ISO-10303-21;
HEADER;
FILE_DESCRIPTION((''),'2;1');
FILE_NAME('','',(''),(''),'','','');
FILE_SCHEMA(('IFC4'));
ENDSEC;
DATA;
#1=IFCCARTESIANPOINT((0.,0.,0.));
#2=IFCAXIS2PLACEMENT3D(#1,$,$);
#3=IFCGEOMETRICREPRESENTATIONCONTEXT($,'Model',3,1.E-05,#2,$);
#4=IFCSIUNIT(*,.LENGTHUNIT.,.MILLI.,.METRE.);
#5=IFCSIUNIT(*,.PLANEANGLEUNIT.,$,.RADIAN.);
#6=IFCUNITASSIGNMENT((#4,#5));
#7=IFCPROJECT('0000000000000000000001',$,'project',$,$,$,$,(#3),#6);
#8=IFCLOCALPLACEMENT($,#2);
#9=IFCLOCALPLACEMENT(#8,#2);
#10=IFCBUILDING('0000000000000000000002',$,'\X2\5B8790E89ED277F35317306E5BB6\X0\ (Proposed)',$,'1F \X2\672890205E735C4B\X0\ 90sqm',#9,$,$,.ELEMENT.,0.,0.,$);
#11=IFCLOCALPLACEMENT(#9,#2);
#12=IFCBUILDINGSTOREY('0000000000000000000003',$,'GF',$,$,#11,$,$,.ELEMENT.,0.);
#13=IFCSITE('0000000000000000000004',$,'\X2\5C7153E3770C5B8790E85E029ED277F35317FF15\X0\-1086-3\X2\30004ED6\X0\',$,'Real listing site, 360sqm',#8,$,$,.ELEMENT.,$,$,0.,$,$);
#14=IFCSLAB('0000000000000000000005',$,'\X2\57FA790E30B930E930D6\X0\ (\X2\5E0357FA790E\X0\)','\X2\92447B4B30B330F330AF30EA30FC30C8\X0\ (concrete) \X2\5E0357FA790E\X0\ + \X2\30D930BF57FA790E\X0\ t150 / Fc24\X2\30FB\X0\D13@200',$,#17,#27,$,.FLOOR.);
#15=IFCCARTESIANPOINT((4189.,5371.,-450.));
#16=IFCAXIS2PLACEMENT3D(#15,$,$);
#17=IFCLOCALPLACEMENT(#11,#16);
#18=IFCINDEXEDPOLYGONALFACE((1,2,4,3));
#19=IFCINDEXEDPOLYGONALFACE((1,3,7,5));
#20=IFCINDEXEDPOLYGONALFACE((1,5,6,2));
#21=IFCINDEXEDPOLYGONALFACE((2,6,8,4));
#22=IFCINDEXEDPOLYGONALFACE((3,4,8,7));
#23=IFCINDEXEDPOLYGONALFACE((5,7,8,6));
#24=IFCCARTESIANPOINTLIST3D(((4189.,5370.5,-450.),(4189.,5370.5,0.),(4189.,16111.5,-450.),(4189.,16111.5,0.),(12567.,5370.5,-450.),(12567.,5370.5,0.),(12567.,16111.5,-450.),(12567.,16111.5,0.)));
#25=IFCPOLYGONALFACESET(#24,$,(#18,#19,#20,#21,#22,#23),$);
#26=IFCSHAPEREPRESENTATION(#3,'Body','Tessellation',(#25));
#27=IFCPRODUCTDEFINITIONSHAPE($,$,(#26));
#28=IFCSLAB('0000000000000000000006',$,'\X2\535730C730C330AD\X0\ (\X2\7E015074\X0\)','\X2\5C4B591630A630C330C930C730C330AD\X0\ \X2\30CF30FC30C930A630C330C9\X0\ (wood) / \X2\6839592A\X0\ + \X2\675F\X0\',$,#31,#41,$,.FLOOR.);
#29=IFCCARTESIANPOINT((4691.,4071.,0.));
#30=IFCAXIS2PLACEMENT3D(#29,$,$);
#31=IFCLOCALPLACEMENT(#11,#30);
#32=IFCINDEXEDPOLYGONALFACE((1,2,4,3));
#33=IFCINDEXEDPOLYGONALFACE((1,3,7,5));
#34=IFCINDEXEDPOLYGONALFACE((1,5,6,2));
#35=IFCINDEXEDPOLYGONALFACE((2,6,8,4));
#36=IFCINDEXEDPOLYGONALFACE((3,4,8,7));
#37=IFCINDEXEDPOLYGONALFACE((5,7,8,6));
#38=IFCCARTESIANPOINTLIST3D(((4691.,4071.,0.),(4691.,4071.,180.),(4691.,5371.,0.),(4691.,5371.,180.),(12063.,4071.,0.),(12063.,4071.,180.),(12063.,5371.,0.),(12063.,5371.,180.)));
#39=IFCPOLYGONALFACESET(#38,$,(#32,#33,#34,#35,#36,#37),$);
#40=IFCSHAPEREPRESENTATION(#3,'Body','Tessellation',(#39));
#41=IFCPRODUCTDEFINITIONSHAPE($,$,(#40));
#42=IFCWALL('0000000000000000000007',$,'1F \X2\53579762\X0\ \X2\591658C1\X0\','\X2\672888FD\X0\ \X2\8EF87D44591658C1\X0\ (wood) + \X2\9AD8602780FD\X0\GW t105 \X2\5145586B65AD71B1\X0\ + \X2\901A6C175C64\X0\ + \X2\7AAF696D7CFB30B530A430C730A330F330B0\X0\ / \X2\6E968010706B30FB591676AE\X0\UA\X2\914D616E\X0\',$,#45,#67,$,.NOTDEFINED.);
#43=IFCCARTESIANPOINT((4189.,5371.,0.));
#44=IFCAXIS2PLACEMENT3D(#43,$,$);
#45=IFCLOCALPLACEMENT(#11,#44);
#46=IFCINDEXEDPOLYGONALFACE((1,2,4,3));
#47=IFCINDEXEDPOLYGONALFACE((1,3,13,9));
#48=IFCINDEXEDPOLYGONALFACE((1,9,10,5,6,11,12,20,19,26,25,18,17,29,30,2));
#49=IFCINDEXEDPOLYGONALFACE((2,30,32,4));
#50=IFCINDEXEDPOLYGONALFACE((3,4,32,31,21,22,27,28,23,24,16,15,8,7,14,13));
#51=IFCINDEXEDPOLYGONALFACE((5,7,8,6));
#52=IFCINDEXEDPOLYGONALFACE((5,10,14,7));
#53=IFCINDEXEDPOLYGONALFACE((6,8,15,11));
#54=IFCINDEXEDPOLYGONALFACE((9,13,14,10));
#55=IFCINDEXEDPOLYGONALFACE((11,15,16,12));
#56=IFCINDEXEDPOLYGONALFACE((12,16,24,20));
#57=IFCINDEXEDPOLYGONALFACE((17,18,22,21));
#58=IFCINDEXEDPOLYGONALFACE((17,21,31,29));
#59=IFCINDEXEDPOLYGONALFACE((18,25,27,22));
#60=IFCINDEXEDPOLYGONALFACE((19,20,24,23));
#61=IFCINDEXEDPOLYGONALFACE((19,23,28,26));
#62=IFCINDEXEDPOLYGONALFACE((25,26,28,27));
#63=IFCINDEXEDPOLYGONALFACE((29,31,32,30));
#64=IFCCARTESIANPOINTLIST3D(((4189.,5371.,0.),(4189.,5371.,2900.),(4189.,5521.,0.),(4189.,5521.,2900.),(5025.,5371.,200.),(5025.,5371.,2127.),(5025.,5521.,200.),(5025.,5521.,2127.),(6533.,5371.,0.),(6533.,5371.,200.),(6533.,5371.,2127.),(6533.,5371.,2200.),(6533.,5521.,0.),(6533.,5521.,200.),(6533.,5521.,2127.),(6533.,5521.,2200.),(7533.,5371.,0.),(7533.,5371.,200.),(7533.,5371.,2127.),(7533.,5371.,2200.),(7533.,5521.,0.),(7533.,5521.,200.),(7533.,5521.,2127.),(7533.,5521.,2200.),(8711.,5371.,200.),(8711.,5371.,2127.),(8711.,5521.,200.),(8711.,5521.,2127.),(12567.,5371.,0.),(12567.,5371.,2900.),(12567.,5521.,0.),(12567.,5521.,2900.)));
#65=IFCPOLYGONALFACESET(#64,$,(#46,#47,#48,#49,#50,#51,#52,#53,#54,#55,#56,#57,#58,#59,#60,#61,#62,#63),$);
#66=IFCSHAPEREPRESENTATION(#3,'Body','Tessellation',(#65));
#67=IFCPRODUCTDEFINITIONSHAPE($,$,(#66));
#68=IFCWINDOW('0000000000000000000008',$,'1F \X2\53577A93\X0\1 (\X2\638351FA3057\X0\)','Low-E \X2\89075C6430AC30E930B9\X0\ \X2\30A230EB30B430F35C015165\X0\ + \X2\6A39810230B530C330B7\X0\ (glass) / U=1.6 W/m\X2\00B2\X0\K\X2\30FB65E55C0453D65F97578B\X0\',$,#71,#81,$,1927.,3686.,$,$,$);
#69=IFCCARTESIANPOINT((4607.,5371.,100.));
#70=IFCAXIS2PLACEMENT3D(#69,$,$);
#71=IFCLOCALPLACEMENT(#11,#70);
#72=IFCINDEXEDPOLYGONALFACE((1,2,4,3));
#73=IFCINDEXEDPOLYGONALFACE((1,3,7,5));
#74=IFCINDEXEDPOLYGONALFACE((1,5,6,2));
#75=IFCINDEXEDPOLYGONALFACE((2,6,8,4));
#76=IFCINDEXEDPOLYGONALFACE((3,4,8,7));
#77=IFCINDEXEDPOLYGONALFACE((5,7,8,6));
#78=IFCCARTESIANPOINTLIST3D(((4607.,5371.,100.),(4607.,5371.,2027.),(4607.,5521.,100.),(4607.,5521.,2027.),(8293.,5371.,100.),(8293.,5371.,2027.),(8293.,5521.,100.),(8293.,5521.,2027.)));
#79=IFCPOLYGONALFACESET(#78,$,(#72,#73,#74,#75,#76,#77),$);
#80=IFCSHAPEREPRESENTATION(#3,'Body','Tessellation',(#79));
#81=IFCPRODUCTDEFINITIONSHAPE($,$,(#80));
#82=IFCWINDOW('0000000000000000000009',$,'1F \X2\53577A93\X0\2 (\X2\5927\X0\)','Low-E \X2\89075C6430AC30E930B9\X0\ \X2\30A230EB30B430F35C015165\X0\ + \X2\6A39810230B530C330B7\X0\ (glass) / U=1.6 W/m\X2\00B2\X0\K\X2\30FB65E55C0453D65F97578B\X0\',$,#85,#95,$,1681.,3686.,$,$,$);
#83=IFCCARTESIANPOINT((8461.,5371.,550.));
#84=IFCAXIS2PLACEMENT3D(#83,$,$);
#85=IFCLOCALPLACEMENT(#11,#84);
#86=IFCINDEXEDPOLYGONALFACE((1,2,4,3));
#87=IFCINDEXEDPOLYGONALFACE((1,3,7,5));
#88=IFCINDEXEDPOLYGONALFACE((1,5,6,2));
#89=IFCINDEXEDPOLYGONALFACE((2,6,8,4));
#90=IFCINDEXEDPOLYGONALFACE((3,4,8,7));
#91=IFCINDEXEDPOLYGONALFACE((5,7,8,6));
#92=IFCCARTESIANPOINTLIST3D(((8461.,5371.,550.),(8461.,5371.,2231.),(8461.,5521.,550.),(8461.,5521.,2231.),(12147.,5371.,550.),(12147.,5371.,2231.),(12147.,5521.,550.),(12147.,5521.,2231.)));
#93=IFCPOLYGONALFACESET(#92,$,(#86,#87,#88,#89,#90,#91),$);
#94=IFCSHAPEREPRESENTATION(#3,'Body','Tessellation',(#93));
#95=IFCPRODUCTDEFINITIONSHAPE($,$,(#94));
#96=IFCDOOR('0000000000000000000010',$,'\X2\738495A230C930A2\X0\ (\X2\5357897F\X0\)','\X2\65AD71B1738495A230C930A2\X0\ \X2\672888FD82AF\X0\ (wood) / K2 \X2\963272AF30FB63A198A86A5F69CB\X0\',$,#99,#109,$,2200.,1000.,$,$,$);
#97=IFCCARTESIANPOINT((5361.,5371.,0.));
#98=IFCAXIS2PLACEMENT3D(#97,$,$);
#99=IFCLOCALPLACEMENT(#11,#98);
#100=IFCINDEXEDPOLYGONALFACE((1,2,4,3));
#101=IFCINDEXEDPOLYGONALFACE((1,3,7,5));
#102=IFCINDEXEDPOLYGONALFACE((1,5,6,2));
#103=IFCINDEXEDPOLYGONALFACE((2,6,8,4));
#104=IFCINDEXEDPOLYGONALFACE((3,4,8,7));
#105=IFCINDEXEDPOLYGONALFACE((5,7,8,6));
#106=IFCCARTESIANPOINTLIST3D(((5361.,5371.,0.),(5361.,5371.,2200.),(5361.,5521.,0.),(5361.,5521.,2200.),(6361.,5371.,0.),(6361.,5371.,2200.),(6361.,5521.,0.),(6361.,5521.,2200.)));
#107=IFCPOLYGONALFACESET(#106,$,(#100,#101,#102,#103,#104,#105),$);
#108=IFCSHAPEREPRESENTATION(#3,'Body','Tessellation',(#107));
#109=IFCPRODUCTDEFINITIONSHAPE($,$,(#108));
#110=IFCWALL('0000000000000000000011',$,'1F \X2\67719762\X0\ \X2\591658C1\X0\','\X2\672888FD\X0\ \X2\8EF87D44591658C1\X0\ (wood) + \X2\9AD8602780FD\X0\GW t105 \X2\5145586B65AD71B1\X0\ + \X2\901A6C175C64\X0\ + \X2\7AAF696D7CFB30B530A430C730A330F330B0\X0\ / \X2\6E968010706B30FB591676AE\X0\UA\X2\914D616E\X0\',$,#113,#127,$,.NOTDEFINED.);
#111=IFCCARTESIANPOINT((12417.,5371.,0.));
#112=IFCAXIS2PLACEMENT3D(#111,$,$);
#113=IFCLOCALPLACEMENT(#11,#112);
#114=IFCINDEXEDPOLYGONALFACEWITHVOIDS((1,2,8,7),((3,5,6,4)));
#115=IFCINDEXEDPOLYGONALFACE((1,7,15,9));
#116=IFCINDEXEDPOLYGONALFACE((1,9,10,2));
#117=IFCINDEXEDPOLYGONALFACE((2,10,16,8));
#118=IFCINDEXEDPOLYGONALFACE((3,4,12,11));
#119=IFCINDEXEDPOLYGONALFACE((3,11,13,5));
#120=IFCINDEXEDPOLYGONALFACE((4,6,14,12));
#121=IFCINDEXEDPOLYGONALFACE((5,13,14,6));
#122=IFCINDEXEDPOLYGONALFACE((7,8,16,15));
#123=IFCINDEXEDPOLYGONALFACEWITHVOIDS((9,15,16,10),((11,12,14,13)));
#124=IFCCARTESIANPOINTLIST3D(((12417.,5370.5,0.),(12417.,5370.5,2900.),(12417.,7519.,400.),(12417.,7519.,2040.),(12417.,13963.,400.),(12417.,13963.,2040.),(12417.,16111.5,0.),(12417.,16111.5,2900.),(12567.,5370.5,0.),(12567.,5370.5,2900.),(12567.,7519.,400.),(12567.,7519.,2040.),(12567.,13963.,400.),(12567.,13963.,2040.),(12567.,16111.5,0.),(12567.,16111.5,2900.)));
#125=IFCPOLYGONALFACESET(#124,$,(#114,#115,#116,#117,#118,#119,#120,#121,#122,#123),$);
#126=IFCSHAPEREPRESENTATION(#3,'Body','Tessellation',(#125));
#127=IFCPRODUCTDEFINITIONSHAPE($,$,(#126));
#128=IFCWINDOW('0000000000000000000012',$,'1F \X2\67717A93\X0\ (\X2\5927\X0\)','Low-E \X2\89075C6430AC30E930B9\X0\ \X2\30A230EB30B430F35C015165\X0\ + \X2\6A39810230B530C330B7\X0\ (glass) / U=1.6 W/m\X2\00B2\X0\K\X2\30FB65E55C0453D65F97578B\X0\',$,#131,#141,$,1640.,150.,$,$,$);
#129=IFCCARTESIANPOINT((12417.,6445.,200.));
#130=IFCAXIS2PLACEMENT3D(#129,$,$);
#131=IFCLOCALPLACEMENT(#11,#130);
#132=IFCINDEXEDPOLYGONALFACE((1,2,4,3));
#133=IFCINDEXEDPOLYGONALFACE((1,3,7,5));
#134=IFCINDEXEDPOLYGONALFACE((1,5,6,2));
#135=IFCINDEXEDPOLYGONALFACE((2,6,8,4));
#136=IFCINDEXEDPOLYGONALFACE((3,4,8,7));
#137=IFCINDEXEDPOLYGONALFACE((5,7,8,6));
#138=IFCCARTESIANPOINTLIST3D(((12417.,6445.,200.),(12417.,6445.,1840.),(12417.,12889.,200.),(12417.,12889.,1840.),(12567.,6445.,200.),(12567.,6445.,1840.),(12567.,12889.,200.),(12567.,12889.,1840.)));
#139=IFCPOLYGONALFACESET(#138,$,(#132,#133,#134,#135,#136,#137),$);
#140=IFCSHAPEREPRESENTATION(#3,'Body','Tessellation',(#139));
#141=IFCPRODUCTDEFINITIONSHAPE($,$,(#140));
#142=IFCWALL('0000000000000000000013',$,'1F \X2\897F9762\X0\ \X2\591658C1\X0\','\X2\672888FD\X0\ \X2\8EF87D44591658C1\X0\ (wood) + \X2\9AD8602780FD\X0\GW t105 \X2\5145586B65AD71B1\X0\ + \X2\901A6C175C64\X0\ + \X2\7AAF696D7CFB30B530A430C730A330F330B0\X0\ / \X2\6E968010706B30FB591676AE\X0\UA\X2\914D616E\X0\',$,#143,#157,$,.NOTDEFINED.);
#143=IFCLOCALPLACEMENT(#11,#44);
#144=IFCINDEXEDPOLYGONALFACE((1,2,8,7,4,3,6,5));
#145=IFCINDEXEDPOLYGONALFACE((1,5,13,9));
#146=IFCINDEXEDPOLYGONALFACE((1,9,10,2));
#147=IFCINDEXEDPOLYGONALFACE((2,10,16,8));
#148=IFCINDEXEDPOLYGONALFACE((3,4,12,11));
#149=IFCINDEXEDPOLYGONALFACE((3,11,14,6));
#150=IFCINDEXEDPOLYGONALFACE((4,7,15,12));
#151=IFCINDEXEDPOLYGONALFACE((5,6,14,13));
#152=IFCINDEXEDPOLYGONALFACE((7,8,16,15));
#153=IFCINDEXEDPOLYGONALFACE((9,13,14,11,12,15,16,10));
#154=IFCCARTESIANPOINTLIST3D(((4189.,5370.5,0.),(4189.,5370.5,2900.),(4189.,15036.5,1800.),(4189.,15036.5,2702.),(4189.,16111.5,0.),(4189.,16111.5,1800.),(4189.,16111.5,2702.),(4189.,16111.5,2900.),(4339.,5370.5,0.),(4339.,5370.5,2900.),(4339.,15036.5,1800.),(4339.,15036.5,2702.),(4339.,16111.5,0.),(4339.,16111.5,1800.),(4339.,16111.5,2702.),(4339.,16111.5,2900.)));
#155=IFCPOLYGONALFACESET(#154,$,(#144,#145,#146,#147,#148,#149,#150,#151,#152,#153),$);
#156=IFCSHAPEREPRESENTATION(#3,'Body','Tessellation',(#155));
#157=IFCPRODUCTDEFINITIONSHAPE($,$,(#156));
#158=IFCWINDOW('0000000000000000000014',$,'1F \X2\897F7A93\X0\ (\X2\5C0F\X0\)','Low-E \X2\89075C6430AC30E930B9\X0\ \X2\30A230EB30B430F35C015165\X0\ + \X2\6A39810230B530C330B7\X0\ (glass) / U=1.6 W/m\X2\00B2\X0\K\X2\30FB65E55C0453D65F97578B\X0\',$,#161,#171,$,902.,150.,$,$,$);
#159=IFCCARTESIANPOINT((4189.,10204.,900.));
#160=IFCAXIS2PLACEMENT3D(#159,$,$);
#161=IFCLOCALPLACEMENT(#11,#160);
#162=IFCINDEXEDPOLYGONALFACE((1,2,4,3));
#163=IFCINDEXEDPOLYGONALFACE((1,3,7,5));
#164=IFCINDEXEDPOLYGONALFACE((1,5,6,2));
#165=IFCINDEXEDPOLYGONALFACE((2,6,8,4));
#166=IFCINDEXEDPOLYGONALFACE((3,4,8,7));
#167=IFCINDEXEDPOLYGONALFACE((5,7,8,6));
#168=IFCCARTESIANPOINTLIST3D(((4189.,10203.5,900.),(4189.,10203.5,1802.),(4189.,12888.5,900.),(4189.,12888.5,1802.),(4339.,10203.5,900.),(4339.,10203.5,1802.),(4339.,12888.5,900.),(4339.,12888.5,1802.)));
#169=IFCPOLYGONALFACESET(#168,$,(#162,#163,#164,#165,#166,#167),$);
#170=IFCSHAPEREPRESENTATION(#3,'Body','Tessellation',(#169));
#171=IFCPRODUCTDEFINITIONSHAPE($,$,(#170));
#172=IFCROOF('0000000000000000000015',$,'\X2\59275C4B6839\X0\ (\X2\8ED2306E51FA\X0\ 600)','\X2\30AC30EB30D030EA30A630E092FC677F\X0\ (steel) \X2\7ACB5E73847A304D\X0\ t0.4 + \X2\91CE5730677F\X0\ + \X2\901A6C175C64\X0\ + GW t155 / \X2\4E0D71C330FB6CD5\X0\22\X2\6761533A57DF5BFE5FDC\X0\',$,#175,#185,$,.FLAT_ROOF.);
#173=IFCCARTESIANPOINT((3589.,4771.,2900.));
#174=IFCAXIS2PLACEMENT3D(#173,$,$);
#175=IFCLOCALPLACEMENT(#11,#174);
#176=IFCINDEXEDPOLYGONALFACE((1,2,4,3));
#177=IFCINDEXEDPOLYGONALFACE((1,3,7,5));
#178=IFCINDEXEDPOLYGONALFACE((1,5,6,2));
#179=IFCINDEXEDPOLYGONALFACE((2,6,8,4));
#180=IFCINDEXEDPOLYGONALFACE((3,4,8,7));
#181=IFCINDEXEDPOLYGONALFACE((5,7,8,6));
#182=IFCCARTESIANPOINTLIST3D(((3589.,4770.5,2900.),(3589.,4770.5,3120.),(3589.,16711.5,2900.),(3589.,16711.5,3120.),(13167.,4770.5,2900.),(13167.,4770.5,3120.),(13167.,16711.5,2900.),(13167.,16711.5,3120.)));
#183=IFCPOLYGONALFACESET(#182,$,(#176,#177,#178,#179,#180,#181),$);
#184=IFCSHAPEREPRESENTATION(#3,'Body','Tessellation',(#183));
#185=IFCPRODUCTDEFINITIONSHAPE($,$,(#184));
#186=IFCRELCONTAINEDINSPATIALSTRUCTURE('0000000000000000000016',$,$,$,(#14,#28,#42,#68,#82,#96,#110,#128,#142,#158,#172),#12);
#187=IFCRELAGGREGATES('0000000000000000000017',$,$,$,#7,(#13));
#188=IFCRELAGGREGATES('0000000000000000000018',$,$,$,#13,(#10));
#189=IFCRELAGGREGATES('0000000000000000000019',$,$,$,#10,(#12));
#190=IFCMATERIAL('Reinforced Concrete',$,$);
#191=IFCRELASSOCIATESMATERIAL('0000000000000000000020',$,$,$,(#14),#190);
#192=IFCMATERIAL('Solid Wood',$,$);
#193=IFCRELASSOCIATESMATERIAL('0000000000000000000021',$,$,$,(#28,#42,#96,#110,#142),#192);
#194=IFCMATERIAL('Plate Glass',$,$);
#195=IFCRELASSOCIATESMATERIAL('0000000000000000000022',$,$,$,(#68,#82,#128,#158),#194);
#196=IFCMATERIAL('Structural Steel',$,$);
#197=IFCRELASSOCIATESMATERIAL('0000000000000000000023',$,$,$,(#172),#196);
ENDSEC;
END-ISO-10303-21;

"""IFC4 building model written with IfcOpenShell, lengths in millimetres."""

from ifc_helpers import new_model, si_unit, frame, frame_2d, origin, place, context, project, spatial, rectangle, extrude, material, element, fill, save


model = new_model("IFC4")

# Units and contexts
model_context = context("Model", 3, precision=1e-05, world=origin())
ifc_project = project(units=[si_unit("LENGTHUNIT", "METRE", prefix="MILLI"), si_unit("PLANEANGLEUNIT", "RADIAN")], contexts=[model_context])

# Site, building, storey
site_placement = place(None, origin())
site = spatial("IfcSite", under=ifc_project, at=site_placement, Name="山口県宇部市黒石北５-1086-3　他", ObjectType="Real listing site, 360sqm", CompositionType="ELEMENT", RefElevation=0.0)
building_placement = place(site_placement, origin())
building = spatial("IfcBuilding", under=site, at=building_placement, Name="宇部黒石北の家 (Proposed)", ObjectType="1F 木造平屋 90sqm", CompositionType="ELEMENT", ElevationOfRefHeight=0.0, ElevationOfTerrain=0.0)
storey_placement = place(building_placement, origin())
storey = spatial("IfcBuildingStorey", under=building, at=storey_placement, Name="GF", CompositionType="ELEMENT", Elevation=0.0)

# Slabs
ifc_material_1 = material(Name="Reinforced Concrete")
slab_1_placement = place(storey_placement, frame((4189.0, 5371.0, -450.0)))
element("IfcSlab", 1, at=slab_1_placement, inside=storey, material=ifc_material_1, Name="基礎スラブ (布基礎)", Description="鉄筋コンクリート (concrete) 布基礎 + ベタ基礎 t150 / Fc24・D13@200", PredefinedType="FLOOR", context=model_context, shape_type="SweptSolid", body=[
    extrude(rectangle(XDim=8378.0, YDim=10741.0, at=frame_2d((4189.0, 5370.0))), frame((4189.0, 5371.0, -450.0)), (0.0, 0.0, 1.0), 450.0),
])
ifc_material_2 = material(Name="Solid Wood")
slab_2_placement = place(storey_placement, frame((4691.0, 4071.0, 0.0)))
element("IfcSlab", 2, at=slab_2_placement, inside=storey, material=ifc_material_2, Name="南デッキ (縁側)", Description="屋外ウッドデッキ ハードウッド (wood) / 根太 + 束", PredefinedType="FLOOR", context=model_context, shape_type="SweptSolid", body=[
    extrude(rectangle(XDim=7372.0, YDim=1300.0, at=frame_2d((3686.0, 650.0))), frame((4691.0, 4071.0, 0.0)), (0.0, 0.0, 1.0), 180.0),
])

# Wall, openings, windows, door
wall_1_placement = place(storey_placement, frame((4189.0, 5371.0, 0.0)))
wall_1 = element("IfcWall", 3, at=wall_1_placement, inside=storey, material=ifc_material_2, Name="1F 南面 外壁", Description="木製 軸組外壁 (wood) + 高性能GW t105 充填断熱 + 通気層 + 窯業系サイディング / 準耐火・外皮UA配慮", PredefinedType="NOTDEFINED", context=model_context, shape_type="SweptSolid", body=[
    extrude(rectangle(XDim=8378.0, YDim=150.0, at=frame_2d((4189.0, 75.0))), frame((4189.0, 5371.0, 0.0)), (0.0, 0.0, 1.0), 2900.0),
])
opening_1_placement = place(storey_placement, frame((4607.0, 5371.0, 100.0)))
opening_1 = element("IfcOpeningElement", 4, at=opening_1_placement, cuts=wall_1, PredefinedType="NOTDEFINED", context=model_context, shape_type="SweptSolid", body=[
    extrude(rectangle(XDim=3686.0, YDim=150.0, at=frame_2d((1843.0, 75.0))), frame((4607.0, 5371.0, 100.0)), (0.0, 0.0, 1.0), 1927.0),
])
opening_2_placement = place(storey_placement, frame((8461.0, 5371.0, 550.0)))
opening_2 = element("IfcOpeningElement", 5, at=opening_2_placement, cuts=wall_1, PredefinedType="NOTDEFINED", context=model_context, shape_type="SweptSolid", body=[
    extrude(rectangle(XDim=3686.0, YDim=150.0, at=frame_2d((1843.0, 75.0))), frame((8461.0, 5371.0, 550.0)), (0.0, 0.0, 1.0), 1681.0),
])
opening_3_placement = place(storey_placement, frame((5361.0, 5371.0, 0.0)))
opening_3 = element("IfcOpeningElement", 6, at=opening_3_placement, cuts=wall_1, PredefinedType="NOTDEFINED", context=model_context, shape_type="SweptSolid", body=[
    extrude(rectangle(XDim=1000.0, YDim=150.0, at=frame_2d((500.0, 75.0))), frame((5361.0, 5371.0, 0.0)), (0.0, 0.0, 1.0), 2200.0),
])
ifc_material_3 = material(Name="Plate Glass")
window_1_placement = place(storey_placement, frame((4607.0, 5371.0, 100.0)))
window_1 = element("IfcWindow", 7, at=window_1_placement, inside=storey, material=ifc_material_3, Name="1F 南窓1 (掃出し)", Description="Low-E 複層ガラス アルゴン封入 + 樹脂サッシ (glass) / U=1.6 W/m²K・日射取得型", OverallHeight=1927.0, OverallWidth=3686.0, context=model_context, shape_type="SweptSolid", body=[
    extrude(rectangle(XDim=3686.0, YDim=150.0, at=frame_2d((1843.0, 75.0))), frame((4607.0, 5371.0, 100.0)), (0.0, 0.0, 1.0), 1927.0),
])
fill(opening_1, window_1)
window_2_placement = place(storey_placement, frame((8461.0, 5371.0, 550.0)))
window_2 = element("IfcWindow", 8, at=window_2_placement, inside=storey, material=ifc_material_3, Name="1F 南窓2 (大)", Description="Low-E 複層ガラス アルゴン封入 + 樹脂サッシ (glass) / U=1.6 W/m²K・日射取得型", OverallHeight=1681.0, OverallWidth=3686.0, context=model_context, shape_type="SweptSolid", body=[
    extrude(rectangle(XDim=3686.0, YDim=150.0, at=frame_2d((1843.0, 75.0))), frame((8461.0, 5371.0, 550.0)), (0.0, 0.0, 1.0), 1681.0),
])
fill(opening_2, window_2)
door_placement = place(storey_placement, frame((5361.0, 5371.0, 0.0)))
door = element("IfcDoor", 9, at=door_placement, inside=storey, material=ifc_material_2, Name="玄関ドア (南西)", Description="断熱玄関ドア 木製芯 (wood) / K2 防犯・採風機構", OverallHeight=2200.0, OverallWidth=1000.0, context=model_context, shape_type="SweptSolid", body=[
    extrude(rectangle(XDim=1000.0, YDim=150.0, at=frame_2d((500.0, 75.0))), frame((5361.0, 5371.0, 0.0)), (0.0, 0.0, 1.0), 2200.0),
])
fill(opening_3, door)

# Walls, openings, windows
wall_2_placement = place(storey_placement, frame((12417.0, 5371.0, 0.0)))
wall_2 = element("IfcWall", 10, at=wall_2_placement, inside=storey, material=ifc_material_2, Name="1F 東面 外壁", Description="木製 軸組外壁 (wood) + 高性能GW t105 充填断熱 + 通気層 + 窯業系サイディング / 準耐火・外皮UA配慮", PredefinedType="NOTDEFINED", context=model_context, shape_type="SweptSolid", body=[
    extrude(rectangle(XDim=150.0, YDim=10741.0, at=frame_2d((75.0, 5370.0))), frame((12417.0, 5371.0, 0.0)), (0.0, 0.0, 1.0), 2900.0),
])
opening_4_placement = place(storey_placement, frame((12417.0, 6445.0, 200.0)))
opening_4 = element("IfcOpeningElement", 11, at=opening_4_placement, cuts=wall_2, PredefinedType="NOTDEFINED", context=model_context, shape_type="SweptSolid", body=[
    extrude(rectangle(XDim=150.0, YDim=6444.0, at=frame_2d((75.0, 3222.0))), frame((12417.0, 6445.0, 200.0)), (0.0, 0.0, 1.0), 1640.0),
])
window_3_placement = place(storey_placement, frame((12417.0, 6445.0, 200.0)))
window_3 = element("IfcWindow", 12, at=window_3_placement, inside=storey, material=ifc_material_3, Name="1F 東窓 (大)", Description="Low-E 複層ガラス アルゴン封入 + 樹脂サッシ (glass) / U=1.6 W/m²K・日射取得型", OverallHeight=1640.0, OverallWidth=150.0, context=model_context, shape_type="SweptSolid", body=[
    extrude(rectangle(XDim=150.0, YDim=6444.0, at=frame_2d((75.0, 3222.0))), frame((12417.0, 6445.0, 200.0)), (0.0, 0.0, 1.0), 1640.0),
])
fill(opening_4, window_3)
wall_3_placement = place(storey_placement, frame((4189.0, 5371.0, 0.0)))
wall_3 = element("IfcWall", 13, at=wall_3_placement, inside=storey, material=ifc_material_2, Name="1F 西面 外壁", Description="木製 軸組外壁 (wood) + 高性能GW t105 充填断熱 + 通気層 + 窯業系サイディング / 準耐火・外皮UA配慮", PredefinedType="NOTDEFINED", context=model_context, shape_type="SweptSolid", body=[
    extrude(rectangle(XDim=150.0, YDim=10741.0, at=frame_2d((75.0, 5370.0))), frame((4189.0, 5371.0, 0.0)), (0.0, 0.0, 1.0), 2900.0),
])
opening_5_placement = place(storey_placement, frame((4189.0, 10204.0, 900.0)))
opening_5 = element("IfcOpeningElement", 14, at=opening_5_placement, cuts=wall_3, PredefinedType="NOTDEFINED", context=model_context, shape_type="SweptSolid", body=[
    extrude(rectangle(XDim=150.0, YDim=2685.0, at=frame_2d((75.0, 1342.0))), frame((4189.0, 10204.0, 900.0)), (0.0, 0.0, 1.0), 902.0),
])
window_4_placement = place(storey_placement, frame((4189.0, 10204.0, 900.0)))
window_4 = element("IfcWindow", 15, at=window_4_placement, inside=storey, material=ifc_material_3, Name="1F 西窓 (小)", Description="Low-E 複層ガラス アルゴン封入 + 樹脂サッシ (glass) / U=1.6 W/m²K・日射取得型", OverallHeight=902.0, OverallWidth=150.0, context=model_context, shape_type="SweptSolid", body=[
    extrude(rectangle(XDim=150.0, YDim=2685.0, at=frame_2d((75.0, 1342.0))), frame((4189.0, 10204.0, 900.0)), (0.0, 0.0, 1.0), 902.0),
])
fill(opening_5, window_4)

# Roof
ifc_material_4 = material(Name="Structural Steel")
roof_placement = place(storey_placement, frame((3589.0, 4771.0, 2900.0)))
element("IfcRoof", 16, at=roof_placement, inside=storey, material=ifc_material_4, Name="大屋根 (軒の出 600)", Description="ガルバリウム鋼板 (steel) 立平葺き t0.4 + 野地板 + 通気層 + GW t155 / 不燃・法22条区域対応", PredefinedType="FLAT_ROOF", context=model_context, shape_type="SweptSolid", body=[
    extrude(rectangle(XDim=9578.0, YDim=11941.0, at=frame_2d((4789.0, 5970.0))), frame((3589.0, 4771.0, 2900.0)), (0.0, 0.0, 1.0), 220.0),
])

save(model, "model.ifc")
